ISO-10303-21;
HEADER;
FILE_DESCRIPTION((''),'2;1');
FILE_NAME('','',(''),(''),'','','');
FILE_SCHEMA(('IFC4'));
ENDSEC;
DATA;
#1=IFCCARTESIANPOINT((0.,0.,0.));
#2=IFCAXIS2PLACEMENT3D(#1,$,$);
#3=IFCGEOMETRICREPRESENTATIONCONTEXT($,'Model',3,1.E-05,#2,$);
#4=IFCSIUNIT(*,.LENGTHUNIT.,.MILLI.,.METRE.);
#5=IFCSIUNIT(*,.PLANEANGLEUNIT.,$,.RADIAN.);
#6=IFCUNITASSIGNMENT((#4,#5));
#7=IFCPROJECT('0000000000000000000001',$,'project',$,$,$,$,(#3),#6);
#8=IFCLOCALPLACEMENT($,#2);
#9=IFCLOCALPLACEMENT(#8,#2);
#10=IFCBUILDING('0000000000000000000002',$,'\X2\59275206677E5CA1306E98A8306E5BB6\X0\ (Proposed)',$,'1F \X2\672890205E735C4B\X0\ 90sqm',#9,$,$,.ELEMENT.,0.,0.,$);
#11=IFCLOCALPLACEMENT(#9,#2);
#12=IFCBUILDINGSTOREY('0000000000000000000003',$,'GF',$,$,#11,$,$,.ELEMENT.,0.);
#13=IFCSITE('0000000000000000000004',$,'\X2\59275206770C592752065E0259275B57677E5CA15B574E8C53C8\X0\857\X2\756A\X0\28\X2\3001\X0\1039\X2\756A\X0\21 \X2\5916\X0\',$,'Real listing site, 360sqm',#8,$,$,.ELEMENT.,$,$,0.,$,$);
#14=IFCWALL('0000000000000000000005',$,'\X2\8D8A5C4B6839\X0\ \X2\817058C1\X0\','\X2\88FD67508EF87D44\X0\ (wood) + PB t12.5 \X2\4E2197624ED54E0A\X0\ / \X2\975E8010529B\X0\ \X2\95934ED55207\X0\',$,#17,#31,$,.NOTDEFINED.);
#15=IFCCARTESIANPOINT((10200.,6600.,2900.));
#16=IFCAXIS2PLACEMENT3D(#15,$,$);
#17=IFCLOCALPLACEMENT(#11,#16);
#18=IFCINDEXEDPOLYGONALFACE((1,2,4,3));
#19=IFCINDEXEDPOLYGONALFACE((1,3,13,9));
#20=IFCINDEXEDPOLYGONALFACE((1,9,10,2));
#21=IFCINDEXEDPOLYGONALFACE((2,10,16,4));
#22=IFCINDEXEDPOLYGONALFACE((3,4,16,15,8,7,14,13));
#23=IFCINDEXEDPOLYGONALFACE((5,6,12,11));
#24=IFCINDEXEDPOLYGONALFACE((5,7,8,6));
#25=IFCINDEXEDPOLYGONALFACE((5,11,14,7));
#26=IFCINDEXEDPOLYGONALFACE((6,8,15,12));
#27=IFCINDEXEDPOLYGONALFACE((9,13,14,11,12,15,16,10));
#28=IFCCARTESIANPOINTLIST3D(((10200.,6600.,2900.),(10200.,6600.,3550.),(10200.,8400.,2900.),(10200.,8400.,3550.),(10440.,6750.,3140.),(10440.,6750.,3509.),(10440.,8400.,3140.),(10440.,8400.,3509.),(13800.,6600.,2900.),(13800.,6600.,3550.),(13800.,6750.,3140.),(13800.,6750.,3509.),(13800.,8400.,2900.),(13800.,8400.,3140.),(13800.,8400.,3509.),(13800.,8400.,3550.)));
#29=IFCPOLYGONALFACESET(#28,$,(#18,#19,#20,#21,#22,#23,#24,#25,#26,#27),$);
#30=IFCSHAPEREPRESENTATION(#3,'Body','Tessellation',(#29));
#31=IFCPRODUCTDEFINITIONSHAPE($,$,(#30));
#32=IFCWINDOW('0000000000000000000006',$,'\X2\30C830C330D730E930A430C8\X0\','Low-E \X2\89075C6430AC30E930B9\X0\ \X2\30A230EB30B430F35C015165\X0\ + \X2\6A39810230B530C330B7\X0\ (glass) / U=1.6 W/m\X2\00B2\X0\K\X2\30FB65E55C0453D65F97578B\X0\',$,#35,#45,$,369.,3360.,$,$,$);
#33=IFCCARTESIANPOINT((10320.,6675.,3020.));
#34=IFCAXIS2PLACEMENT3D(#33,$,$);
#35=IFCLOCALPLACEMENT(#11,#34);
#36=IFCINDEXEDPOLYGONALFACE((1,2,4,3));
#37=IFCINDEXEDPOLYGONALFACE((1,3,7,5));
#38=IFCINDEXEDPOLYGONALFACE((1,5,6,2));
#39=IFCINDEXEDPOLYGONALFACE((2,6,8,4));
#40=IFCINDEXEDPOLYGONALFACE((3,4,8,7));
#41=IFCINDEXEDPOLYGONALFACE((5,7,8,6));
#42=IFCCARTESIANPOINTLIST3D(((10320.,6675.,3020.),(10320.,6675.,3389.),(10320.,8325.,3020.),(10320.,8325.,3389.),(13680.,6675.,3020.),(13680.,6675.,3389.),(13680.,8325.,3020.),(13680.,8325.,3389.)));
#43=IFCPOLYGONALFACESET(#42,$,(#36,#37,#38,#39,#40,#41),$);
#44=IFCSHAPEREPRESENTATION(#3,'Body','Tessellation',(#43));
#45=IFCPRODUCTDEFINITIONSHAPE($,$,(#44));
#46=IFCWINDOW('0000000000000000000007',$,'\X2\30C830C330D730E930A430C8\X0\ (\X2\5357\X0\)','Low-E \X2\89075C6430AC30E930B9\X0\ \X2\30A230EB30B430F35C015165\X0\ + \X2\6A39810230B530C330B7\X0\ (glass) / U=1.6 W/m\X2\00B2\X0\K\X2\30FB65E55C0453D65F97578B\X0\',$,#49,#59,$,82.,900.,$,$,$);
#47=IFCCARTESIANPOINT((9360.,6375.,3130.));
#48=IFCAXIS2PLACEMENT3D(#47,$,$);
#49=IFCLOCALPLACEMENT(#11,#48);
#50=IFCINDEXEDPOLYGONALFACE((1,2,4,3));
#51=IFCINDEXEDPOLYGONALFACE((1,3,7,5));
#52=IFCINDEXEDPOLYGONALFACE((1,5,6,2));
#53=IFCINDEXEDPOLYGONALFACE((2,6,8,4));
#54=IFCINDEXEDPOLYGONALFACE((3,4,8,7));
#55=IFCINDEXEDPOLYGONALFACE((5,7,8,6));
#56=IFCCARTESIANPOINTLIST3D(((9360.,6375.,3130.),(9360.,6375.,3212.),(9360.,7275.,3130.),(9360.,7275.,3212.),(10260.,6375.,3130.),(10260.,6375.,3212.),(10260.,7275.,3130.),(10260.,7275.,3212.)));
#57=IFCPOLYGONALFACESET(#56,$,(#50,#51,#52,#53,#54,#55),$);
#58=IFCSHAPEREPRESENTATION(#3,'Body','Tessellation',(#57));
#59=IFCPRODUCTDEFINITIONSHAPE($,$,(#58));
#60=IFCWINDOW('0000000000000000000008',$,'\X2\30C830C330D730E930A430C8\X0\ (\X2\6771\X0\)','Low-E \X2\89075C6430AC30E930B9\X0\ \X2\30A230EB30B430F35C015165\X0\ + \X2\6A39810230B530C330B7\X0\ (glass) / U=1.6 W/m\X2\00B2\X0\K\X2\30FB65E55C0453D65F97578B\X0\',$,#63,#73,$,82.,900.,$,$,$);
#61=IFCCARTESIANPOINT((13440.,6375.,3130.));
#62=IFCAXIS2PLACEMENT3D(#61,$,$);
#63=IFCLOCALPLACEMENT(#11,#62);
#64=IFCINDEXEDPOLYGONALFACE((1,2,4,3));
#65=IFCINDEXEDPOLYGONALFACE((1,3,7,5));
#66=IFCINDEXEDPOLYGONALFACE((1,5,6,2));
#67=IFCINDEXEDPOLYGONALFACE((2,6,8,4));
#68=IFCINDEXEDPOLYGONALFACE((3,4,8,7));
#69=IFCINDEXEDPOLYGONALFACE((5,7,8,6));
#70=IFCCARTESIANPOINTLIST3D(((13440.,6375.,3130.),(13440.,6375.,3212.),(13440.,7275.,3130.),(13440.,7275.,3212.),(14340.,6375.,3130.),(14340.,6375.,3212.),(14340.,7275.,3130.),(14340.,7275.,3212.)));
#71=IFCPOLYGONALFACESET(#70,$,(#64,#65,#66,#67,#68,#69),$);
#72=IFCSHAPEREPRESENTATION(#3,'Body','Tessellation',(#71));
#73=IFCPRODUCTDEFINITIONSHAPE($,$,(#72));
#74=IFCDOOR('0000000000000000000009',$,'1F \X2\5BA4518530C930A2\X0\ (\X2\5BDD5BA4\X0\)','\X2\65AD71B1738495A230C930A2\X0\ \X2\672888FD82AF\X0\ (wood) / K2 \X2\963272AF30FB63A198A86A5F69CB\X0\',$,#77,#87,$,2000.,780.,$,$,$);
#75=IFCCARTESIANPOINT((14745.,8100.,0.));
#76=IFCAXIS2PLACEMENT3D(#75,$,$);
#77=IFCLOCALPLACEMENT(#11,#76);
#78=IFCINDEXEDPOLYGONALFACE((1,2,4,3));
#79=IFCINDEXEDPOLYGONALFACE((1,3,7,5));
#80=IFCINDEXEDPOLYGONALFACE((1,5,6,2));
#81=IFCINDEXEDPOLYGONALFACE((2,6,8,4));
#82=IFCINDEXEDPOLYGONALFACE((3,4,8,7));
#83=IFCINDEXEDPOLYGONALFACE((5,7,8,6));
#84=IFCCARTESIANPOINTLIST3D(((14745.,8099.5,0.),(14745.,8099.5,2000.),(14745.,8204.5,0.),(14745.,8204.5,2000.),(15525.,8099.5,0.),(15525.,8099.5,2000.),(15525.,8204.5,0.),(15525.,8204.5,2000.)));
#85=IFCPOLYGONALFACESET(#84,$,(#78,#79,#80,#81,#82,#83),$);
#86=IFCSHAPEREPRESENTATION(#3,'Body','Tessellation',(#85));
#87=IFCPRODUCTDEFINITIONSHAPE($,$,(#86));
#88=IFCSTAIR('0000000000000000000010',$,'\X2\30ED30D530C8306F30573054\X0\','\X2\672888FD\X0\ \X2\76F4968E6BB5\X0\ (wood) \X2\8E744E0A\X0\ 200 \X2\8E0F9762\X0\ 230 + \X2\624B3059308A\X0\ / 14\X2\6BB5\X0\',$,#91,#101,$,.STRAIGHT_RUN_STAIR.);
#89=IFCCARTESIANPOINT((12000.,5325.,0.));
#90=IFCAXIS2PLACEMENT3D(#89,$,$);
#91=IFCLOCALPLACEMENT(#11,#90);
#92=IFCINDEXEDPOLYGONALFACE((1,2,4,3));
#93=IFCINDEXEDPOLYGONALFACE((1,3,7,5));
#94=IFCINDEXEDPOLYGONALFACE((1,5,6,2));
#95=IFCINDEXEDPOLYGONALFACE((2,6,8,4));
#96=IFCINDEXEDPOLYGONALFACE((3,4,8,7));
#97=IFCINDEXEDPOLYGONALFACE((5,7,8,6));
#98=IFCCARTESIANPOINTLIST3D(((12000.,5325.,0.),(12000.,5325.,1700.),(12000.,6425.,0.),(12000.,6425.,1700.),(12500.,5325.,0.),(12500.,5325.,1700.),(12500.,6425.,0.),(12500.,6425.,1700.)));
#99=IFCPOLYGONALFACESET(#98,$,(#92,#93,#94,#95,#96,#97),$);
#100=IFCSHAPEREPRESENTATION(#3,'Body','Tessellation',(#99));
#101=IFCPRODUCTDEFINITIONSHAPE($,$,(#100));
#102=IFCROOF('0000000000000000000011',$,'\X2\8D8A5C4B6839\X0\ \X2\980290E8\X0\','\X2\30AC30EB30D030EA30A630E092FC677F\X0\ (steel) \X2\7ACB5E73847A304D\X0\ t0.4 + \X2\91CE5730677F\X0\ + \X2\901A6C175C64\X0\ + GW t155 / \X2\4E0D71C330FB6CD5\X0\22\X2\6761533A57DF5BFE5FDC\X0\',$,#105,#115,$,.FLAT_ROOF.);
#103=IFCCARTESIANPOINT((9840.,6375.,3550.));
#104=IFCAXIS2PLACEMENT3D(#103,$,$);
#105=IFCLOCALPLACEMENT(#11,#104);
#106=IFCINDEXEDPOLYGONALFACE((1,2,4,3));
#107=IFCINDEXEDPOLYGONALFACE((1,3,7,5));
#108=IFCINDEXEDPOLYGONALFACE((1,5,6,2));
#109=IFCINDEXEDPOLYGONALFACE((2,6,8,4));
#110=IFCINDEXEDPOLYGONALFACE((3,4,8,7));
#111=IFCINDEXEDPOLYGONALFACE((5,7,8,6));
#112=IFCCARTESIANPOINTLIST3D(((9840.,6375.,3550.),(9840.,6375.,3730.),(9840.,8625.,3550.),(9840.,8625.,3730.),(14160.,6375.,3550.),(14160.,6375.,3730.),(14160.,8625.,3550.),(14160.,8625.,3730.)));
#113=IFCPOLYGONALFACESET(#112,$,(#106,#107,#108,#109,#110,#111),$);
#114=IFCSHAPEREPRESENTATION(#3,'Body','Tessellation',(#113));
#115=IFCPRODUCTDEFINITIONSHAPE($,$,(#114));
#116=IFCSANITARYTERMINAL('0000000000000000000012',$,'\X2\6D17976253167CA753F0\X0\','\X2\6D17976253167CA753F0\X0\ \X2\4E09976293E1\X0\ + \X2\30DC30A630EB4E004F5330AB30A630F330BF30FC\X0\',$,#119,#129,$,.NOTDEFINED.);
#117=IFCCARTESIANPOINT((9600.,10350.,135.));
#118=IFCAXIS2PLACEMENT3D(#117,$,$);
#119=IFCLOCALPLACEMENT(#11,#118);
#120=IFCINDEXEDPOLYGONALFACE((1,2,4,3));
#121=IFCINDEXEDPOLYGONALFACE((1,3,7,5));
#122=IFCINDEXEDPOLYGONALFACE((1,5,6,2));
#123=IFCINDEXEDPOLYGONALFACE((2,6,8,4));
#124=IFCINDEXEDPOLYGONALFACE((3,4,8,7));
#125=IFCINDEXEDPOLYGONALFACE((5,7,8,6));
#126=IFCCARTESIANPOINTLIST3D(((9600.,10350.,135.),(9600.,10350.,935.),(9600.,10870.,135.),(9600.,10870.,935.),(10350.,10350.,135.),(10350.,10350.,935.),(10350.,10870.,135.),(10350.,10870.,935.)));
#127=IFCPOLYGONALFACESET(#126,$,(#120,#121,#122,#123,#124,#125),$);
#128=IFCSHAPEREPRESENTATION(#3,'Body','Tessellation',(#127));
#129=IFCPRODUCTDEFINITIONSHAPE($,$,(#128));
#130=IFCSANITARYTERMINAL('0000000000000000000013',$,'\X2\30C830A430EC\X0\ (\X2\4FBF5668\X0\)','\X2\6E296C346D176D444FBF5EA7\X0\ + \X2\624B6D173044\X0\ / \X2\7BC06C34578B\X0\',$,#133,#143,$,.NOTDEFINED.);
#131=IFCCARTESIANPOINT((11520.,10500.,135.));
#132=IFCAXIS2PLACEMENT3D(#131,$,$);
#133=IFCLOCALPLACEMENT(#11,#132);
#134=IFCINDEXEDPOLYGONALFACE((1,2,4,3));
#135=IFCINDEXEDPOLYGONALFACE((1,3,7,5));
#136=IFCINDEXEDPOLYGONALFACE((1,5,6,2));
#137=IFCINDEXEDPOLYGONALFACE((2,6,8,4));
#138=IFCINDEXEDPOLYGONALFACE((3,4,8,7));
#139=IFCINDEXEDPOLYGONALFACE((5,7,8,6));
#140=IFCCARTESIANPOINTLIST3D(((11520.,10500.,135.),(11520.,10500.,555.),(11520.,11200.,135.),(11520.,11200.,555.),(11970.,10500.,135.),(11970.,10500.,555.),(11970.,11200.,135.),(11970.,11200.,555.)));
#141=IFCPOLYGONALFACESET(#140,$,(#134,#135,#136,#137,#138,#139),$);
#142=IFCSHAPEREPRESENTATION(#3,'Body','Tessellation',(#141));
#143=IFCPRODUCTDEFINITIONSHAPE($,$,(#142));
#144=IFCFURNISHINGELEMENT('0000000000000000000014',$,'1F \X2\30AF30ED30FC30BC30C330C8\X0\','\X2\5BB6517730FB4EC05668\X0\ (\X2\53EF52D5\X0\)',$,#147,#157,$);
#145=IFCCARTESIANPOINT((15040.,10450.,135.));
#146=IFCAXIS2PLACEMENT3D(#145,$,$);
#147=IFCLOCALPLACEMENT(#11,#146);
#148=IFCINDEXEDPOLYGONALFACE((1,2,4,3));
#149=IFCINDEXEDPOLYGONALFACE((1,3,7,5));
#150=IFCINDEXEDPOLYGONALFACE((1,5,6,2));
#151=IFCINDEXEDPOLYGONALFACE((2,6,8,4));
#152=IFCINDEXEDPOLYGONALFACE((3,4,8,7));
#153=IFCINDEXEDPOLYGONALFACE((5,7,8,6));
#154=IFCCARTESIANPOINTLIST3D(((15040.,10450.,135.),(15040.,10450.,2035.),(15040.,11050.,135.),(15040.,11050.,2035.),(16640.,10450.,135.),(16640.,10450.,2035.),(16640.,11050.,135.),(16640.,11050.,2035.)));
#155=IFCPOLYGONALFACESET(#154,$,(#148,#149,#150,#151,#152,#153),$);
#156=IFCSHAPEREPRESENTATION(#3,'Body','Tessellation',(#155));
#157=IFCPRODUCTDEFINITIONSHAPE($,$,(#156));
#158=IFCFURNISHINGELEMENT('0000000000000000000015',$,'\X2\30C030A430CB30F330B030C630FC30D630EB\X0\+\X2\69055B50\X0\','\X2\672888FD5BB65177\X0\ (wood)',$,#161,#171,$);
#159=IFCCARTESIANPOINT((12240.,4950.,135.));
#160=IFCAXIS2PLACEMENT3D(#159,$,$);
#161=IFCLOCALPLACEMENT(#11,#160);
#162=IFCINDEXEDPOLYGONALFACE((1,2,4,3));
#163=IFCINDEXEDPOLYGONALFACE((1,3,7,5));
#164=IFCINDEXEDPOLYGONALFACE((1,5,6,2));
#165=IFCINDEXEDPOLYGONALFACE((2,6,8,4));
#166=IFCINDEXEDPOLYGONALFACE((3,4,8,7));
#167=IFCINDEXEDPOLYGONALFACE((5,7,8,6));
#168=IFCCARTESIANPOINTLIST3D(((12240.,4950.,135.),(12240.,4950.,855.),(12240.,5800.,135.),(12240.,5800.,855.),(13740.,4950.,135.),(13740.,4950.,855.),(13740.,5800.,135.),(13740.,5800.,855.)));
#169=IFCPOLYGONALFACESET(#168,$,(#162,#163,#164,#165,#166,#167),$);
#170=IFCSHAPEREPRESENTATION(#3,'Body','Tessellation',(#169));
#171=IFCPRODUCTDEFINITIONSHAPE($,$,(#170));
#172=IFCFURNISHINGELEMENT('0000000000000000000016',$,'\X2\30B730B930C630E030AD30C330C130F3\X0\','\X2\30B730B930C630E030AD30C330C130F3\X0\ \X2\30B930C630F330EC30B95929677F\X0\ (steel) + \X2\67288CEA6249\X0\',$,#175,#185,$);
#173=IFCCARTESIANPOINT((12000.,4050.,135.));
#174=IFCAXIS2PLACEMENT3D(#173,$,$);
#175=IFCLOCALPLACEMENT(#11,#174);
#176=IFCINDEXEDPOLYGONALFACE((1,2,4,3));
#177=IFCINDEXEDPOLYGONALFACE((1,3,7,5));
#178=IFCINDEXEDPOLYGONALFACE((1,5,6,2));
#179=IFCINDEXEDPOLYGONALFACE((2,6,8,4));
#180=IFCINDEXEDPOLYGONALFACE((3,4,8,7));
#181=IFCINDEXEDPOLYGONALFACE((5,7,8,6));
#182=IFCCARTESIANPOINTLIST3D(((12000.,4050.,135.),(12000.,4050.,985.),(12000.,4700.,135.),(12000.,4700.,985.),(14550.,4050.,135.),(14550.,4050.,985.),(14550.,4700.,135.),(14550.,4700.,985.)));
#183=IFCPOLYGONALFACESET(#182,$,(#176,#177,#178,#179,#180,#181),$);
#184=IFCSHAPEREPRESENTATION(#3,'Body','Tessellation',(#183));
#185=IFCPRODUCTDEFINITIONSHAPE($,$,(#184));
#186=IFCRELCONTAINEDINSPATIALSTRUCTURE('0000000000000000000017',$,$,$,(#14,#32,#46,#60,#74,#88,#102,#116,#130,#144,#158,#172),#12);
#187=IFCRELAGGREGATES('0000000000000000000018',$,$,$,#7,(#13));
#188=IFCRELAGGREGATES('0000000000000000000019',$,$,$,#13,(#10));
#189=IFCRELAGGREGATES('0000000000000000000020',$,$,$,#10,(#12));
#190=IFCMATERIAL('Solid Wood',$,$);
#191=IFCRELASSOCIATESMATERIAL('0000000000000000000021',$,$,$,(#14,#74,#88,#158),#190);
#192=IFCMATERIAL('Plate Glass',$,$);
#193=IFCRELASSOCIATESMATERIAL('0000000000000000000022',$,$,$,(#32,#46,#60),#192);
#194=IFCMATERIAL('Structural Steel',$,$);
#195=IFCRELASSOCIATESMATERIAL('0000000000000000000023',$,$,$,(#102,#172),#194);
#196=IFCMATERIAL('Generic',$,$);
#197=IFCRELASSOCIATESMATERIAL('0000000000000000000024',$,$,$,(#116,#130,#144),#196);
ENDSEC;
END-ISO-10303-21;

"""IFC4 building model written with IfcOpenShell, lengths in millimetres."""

from ifc_helpers import new_model, si_unit, frame, frame_2d, origin, place, context, project, spatial, rectangle, extrude, material, element, fill, save


model = new_model("IFC4")

# Units and contexts
model_context = context("Model", 3, precision=1e-05, world=origin())
ifc_project = project(units=[si_unit("LENGTHUNIT", "METRE", prefix="MILLI"), si_unit("PLANEANGLEUNIT", "RADIAN")], contexts=[model_context])

# Site, building, storey
site_placement = place(None, origin())
site = spatial("IfcSite", under=ifc_project, at=site_placement, Name="大分県大分市大字松岡字二又857番28、1039番21 外", ObjectType="Real listing site, 360sqm", CompositionType="ELEMENT", RefElevation=0.0)
building_placement = place(site_placement, origin())
building = spatial("IfcBuilding", under=site, at=building_placement, Name="大分松岡の風の家 (Proposed)", ObjectType="1F 木造平屋 90sqm", CompositionType="ELEMENT", ElevationOfRefHeight=0.0, ElevationOfTerrain=0.0)
storey_placement = place(building_placement, origin())
storey = spatial("IfcBuildingStorey", under=building, at=storey_placement, Name="GF", CompositionType="ELEMENT", Elevation=0.0)

# Shared definitions
ifc_material_1 = material(Name="Solid Wood")
ifc_material_2 = material(Name="Plate Glass")

# Wall, openings, windows
wall_1_placement = place(storey_placement, frame((10200.0, 6600.0, 2900.0)))
wall_1 = element("IfcWall", 1, at=wall_1_placement, inside=storey, material=ifc_material_1, Name="越屋根 腰壁", Description="製材軸組 (wood) + PB t12.5 両面仕上 / 非耐力 間仕切", PredefinedType="NOTDEFINED", context=model_context, shape_type="SweptSolid", body=[
    extrude(rectangle(XDim=3600.0, YDim=1800.0, at=frame_2d((1800.0, 900.0))), frame((10200.0, 6600.0, 2900.0)), (0.0, 0.0, 1.0), 650.0),
])
opening_1_placement = place(storey_placement, frame((10320.0, 6675.0, 3020.0)))
opening_1 = element("IfcOpeningElement", 2, at=opening_1_placement, cuts=wall_1, PredefinedType="NOTDEFINED", context=model_context, shape_type="SweptSolid", body=[
    extrude(rectangle(XDim=3360.0, YDim=1650.0, at=frame_2d((1680.0, 825.0))), frame((10320.0, 6675.0, 3020.0)), (0.0, 0.0, 1.0), 369.0),
])
opening_2_placement = place(storey_placement, frame((9360.0, 6375.0, 3130.0)))
opening_2 = element("IfcOpeningElement", 3, at=opening_2_placement, cuts=wall_1, PredefinedType="NOTDEFINED", context=model_context, shape_type="SweptSolid", body=[
    extrude(rectangle(XDim=900.0, YDim=900.0, at=frame_2d((450.0, 450.0))), frame((9360.0, 6375.0, 3130.0)), (0.0, 0.0, 1.0), 82.0),
])
opening_3_placement = place(storey_placement, frame((13440.0, 6375.0, 3130.0)))
opening_3 = element("IfcOpeningElement", 4, at=opening_3_placement, cuts=wall_1, PredefinedType="NOTDEFINED", context=model_context, shape_type="SweptSolid", body=[
    extrude(rectangle(XDim=900.0, YDim=900.0, at=frame_2d((450.0, 450.0))), frame((13440.0, 6375.0, 3130.0)), (0.0, 0.0, 1.0), 82.0),
])
window_1_placement = place(storey_placement, frame((10320.0, 6675.0, 3020.0)))
window_1 = element("IfcWindow", 5, at=window_1_placement, inside=storey, material=ifc_material_2, Name="トップライト", Description="Low-E 複層ガラス アルゴン封入 + 樹脂サッシ (glass) / U=1.6 W/m²K・日射取得型", OverallHeight=369.0, OverallWidth=3360.0, context=model_context, shape_type="SweptSolid", body=[
    extrude(rectangle(XDim=3360.0, YDim=1650.0, at=frame_2d((1680.0, 825.0))), frame((10320.0, 6675.0, 3020.0)), (0.0, 0.0, 1.0), 369.0),
])
fill(opening_1, window_1)
window_2_placement = place(storey_placement, frame((9360.0, 6375.0, 3130.0)))
window_2 = element("IfcWindow", 6, at=window_2_placement, inside=storey, material=ifc_material_2, Name="トップライト (南)", Description="Low-E 複層ガラス アルゴン封入 + 樹脂サッシ (glass) / U=1.6 W/m²K・日射取得型", OverallHeight=82.0, OverallWidth=900.0, context=model_context, shape_type="SweptSolid", body=[
    extrude(rectangle(XDim=900.0, YDim=900.0, at=frame_2d((450.0, 450.0))), frame((9360.0, 6375.0, 3130.0)), (0.0, 0.0, 1.0), 82.0),
])
fill(opening_2, window_2)
window_3_placement = place(storey_placement, frame((13440.0, 6375.0, 3130.0)))
window_3 = element("IfcWindow", 7, at=window_3_placement, inside=storey, material=ifc_material_2, Name="トップライト (東)", Description="Low-E 複層ガラス アルゴン封入 + 樹脂サッシ (glass) / U=1.6 W/m²K・日射取得型", OverallHeight=82.0, OverallWidth=900.0, context=model_context, shape_type="SweptSolid", body=[
    extrude(rectangle(XDim=900.0, YDim=900.0, at=frame_2d((450.0, 450.0))), frame((13440.0, 6375.0, 3130.0)), (0.0, 0.0, 1.0), 82.0),
])
fill(opening_3, window_3)

# Door
door_placement = place(storey_placement, frame((14745.0, 8100.0, 0.0)))
element("IfcDoor", 8, at=door_placement, inside=storey, material=ifc_material_1, Name="1F 室内ドア (寝室)", Description="断熱玄関ドア 木製芯 (wood) / K2 防犯・採風機構", OverallHeight=2000.0, OverallWidth=780.0, context=model_context, shape_type="SweptSolid", body=[
    extrude(rectangle(XDim=780.0, YDim=105.0, at=frame_2d((390.0, 52.0))), frame((14745.0, 8100.0, 0.0)), (0.0, 0.0, 1.0), 2000.0),
])

# Stair
stair_placement = place(storey_placement, frame((12000.0, 5325.0, 0.0)))
element("IfcStair", 9, at=stair_placement, inside=storey, material=ifc_material_1, Name="ロフトはしご", Description="木製 直階段 (wood) 蹴上 200 踏面 230 + 手すり / 14段", PredefinedType="STRAIGHT_RUN_STAIR", context=model_context, shape_type="SweptSolid", body=[
    extrude(rectangle(XDim=500.0, YDim=1100.0, at=frame_2d((250.0, 550.0))), frame((12000.0, 5325.0, 0.0)), (0.0, 0.0, 1.0), 1700.0),
])

# Roof
ifc_material_3 = material(Name="Structural Steel")
roof_placement = place(storey_placement, frame((9840.0, 6375.0, 3550.0)))
element("IfcRoof", 10, at=roof_placement, inside=storey, material=ifc_material_3, Name="越屋根 頂部", Description="ガルバリウム鋼板 (steel) 立平葺き t0.4 + 野地板 + 通気層 + GW t155 / 不燃・法22条区域対応", PredefinedType="FLAT_ROOF", context=model_context, shape_type="SweptSolid", body=[
    extrude(rectangle(XDim=4320.0, YDim=2250.0, at=frame_2d((2160.0, 1125.0))), frame((9840.0, 6375.0, 3550.0)), (0.0, 0.0, 1.0), 180.0),
])

# Sanitary terminals
ifc_material_4 = material(Name="Generic")
sanitary_terminal_1_placement = place(storey_placement, frame((9600.0, 10350.0, 135.0)))
element("IfcSanitaryTerminal", 11, at=sanitary_terminal_1_placement, inside=storey, material=ifc_material_4, Name="洗面化粧台", Description="洗面化粧台 三面鏡 + ボウル一体カウンター", PredefinedType="NOTDEFINED", context=model_context, shape_type="SweptSolid", body=[
    extrude(rectangle(XDim=750.0, YDim=520.0, at=frame_2d((375.0, 260.0))), frame((9600.0, 10350.0, 135.0)), (0.0, 0.0, 1.0), 800.0),
])
sanitary_terminal_2_placement = place(storey_placement, frame((11520.0, 10500.0, 135.0)))
element("IfcSanitaryTerminal", 12, at=sanitary_terminal_2_placement, inside=storey, material=ifc_material_4, Name="トイレ (便器)", Description="温水洗浄便座 + 手洗い / 節水型", PredefinedType="NOTDEFINED", context=model_context, shape_type="SweptSolid", body=[
    extrude(rectangle(XDim=450.0, YDim=700.0, at=frame_2d((225.0, 350.0))), frame((11520.0, 10500.0, 135.0)), (0.0, 0.0, 1.0), 420.0),
])

# Furnishing elements
furnishing_1_placement = place(storey_placement, frame((15040.0, 10450.0, 135.0)))
element("IfcFurnishingElement", 13, at=furnishing_1_placement, inside=storey, material=ifc_material_4, Name="1F クローゼット", Description="家具・什器 (可動)", context=model_context, shape_type="SweptSolid", body=[
    extrude(rectangle(XDim=1600.0, YDim=600.0, at=frame_2d((800.0, 300.0))), frame((15040.0, 10450.0, 135.0)), (0.0, 0.0, 1.0), 1900.0),
])
furnishing_2_placement = place(storey_placement, frame((12240.0, 4950.0, 135.0)))
element("IfcFurnishingElement", 14, at=furnishing_2_placement, inside=storey, material=ifc_material_1, Name="ダイニングテーブル+椅子", Description="木製家具 (wood)", context=model_context, shape_type="SweptSolid", body=[
    extrude(rectangle(XDim=1500.0, YDim=850.0, at=frame_2d((750.0, 425.0))), frame((12240.0, 4950.0, 135.0)), (0.0, 0.0, 1.0), 720.0),
])
furnishing_3_placement = place(storey_placement, frame((12000.0, 4050.0, 135.0)))
element("IfcFurnishingElement", 15, at=furnishing_3_placement, inside=storey, material=ifc_material_3, Name="システムキッチン", Description="システムキッチン ステンレス天板 (steel) + 木質扉", context=model_context, shape_type="SweptSolid", body=[
    extrude(rectangle(XDim=2550.0, YDim=650.0, at=frame_2d((1275.0, 325.0))), frame((12000.0, 4050.0, 135.0)), (0.0, 0.0, 1.0), 850.0),
])

save(model, "model.ifc")
